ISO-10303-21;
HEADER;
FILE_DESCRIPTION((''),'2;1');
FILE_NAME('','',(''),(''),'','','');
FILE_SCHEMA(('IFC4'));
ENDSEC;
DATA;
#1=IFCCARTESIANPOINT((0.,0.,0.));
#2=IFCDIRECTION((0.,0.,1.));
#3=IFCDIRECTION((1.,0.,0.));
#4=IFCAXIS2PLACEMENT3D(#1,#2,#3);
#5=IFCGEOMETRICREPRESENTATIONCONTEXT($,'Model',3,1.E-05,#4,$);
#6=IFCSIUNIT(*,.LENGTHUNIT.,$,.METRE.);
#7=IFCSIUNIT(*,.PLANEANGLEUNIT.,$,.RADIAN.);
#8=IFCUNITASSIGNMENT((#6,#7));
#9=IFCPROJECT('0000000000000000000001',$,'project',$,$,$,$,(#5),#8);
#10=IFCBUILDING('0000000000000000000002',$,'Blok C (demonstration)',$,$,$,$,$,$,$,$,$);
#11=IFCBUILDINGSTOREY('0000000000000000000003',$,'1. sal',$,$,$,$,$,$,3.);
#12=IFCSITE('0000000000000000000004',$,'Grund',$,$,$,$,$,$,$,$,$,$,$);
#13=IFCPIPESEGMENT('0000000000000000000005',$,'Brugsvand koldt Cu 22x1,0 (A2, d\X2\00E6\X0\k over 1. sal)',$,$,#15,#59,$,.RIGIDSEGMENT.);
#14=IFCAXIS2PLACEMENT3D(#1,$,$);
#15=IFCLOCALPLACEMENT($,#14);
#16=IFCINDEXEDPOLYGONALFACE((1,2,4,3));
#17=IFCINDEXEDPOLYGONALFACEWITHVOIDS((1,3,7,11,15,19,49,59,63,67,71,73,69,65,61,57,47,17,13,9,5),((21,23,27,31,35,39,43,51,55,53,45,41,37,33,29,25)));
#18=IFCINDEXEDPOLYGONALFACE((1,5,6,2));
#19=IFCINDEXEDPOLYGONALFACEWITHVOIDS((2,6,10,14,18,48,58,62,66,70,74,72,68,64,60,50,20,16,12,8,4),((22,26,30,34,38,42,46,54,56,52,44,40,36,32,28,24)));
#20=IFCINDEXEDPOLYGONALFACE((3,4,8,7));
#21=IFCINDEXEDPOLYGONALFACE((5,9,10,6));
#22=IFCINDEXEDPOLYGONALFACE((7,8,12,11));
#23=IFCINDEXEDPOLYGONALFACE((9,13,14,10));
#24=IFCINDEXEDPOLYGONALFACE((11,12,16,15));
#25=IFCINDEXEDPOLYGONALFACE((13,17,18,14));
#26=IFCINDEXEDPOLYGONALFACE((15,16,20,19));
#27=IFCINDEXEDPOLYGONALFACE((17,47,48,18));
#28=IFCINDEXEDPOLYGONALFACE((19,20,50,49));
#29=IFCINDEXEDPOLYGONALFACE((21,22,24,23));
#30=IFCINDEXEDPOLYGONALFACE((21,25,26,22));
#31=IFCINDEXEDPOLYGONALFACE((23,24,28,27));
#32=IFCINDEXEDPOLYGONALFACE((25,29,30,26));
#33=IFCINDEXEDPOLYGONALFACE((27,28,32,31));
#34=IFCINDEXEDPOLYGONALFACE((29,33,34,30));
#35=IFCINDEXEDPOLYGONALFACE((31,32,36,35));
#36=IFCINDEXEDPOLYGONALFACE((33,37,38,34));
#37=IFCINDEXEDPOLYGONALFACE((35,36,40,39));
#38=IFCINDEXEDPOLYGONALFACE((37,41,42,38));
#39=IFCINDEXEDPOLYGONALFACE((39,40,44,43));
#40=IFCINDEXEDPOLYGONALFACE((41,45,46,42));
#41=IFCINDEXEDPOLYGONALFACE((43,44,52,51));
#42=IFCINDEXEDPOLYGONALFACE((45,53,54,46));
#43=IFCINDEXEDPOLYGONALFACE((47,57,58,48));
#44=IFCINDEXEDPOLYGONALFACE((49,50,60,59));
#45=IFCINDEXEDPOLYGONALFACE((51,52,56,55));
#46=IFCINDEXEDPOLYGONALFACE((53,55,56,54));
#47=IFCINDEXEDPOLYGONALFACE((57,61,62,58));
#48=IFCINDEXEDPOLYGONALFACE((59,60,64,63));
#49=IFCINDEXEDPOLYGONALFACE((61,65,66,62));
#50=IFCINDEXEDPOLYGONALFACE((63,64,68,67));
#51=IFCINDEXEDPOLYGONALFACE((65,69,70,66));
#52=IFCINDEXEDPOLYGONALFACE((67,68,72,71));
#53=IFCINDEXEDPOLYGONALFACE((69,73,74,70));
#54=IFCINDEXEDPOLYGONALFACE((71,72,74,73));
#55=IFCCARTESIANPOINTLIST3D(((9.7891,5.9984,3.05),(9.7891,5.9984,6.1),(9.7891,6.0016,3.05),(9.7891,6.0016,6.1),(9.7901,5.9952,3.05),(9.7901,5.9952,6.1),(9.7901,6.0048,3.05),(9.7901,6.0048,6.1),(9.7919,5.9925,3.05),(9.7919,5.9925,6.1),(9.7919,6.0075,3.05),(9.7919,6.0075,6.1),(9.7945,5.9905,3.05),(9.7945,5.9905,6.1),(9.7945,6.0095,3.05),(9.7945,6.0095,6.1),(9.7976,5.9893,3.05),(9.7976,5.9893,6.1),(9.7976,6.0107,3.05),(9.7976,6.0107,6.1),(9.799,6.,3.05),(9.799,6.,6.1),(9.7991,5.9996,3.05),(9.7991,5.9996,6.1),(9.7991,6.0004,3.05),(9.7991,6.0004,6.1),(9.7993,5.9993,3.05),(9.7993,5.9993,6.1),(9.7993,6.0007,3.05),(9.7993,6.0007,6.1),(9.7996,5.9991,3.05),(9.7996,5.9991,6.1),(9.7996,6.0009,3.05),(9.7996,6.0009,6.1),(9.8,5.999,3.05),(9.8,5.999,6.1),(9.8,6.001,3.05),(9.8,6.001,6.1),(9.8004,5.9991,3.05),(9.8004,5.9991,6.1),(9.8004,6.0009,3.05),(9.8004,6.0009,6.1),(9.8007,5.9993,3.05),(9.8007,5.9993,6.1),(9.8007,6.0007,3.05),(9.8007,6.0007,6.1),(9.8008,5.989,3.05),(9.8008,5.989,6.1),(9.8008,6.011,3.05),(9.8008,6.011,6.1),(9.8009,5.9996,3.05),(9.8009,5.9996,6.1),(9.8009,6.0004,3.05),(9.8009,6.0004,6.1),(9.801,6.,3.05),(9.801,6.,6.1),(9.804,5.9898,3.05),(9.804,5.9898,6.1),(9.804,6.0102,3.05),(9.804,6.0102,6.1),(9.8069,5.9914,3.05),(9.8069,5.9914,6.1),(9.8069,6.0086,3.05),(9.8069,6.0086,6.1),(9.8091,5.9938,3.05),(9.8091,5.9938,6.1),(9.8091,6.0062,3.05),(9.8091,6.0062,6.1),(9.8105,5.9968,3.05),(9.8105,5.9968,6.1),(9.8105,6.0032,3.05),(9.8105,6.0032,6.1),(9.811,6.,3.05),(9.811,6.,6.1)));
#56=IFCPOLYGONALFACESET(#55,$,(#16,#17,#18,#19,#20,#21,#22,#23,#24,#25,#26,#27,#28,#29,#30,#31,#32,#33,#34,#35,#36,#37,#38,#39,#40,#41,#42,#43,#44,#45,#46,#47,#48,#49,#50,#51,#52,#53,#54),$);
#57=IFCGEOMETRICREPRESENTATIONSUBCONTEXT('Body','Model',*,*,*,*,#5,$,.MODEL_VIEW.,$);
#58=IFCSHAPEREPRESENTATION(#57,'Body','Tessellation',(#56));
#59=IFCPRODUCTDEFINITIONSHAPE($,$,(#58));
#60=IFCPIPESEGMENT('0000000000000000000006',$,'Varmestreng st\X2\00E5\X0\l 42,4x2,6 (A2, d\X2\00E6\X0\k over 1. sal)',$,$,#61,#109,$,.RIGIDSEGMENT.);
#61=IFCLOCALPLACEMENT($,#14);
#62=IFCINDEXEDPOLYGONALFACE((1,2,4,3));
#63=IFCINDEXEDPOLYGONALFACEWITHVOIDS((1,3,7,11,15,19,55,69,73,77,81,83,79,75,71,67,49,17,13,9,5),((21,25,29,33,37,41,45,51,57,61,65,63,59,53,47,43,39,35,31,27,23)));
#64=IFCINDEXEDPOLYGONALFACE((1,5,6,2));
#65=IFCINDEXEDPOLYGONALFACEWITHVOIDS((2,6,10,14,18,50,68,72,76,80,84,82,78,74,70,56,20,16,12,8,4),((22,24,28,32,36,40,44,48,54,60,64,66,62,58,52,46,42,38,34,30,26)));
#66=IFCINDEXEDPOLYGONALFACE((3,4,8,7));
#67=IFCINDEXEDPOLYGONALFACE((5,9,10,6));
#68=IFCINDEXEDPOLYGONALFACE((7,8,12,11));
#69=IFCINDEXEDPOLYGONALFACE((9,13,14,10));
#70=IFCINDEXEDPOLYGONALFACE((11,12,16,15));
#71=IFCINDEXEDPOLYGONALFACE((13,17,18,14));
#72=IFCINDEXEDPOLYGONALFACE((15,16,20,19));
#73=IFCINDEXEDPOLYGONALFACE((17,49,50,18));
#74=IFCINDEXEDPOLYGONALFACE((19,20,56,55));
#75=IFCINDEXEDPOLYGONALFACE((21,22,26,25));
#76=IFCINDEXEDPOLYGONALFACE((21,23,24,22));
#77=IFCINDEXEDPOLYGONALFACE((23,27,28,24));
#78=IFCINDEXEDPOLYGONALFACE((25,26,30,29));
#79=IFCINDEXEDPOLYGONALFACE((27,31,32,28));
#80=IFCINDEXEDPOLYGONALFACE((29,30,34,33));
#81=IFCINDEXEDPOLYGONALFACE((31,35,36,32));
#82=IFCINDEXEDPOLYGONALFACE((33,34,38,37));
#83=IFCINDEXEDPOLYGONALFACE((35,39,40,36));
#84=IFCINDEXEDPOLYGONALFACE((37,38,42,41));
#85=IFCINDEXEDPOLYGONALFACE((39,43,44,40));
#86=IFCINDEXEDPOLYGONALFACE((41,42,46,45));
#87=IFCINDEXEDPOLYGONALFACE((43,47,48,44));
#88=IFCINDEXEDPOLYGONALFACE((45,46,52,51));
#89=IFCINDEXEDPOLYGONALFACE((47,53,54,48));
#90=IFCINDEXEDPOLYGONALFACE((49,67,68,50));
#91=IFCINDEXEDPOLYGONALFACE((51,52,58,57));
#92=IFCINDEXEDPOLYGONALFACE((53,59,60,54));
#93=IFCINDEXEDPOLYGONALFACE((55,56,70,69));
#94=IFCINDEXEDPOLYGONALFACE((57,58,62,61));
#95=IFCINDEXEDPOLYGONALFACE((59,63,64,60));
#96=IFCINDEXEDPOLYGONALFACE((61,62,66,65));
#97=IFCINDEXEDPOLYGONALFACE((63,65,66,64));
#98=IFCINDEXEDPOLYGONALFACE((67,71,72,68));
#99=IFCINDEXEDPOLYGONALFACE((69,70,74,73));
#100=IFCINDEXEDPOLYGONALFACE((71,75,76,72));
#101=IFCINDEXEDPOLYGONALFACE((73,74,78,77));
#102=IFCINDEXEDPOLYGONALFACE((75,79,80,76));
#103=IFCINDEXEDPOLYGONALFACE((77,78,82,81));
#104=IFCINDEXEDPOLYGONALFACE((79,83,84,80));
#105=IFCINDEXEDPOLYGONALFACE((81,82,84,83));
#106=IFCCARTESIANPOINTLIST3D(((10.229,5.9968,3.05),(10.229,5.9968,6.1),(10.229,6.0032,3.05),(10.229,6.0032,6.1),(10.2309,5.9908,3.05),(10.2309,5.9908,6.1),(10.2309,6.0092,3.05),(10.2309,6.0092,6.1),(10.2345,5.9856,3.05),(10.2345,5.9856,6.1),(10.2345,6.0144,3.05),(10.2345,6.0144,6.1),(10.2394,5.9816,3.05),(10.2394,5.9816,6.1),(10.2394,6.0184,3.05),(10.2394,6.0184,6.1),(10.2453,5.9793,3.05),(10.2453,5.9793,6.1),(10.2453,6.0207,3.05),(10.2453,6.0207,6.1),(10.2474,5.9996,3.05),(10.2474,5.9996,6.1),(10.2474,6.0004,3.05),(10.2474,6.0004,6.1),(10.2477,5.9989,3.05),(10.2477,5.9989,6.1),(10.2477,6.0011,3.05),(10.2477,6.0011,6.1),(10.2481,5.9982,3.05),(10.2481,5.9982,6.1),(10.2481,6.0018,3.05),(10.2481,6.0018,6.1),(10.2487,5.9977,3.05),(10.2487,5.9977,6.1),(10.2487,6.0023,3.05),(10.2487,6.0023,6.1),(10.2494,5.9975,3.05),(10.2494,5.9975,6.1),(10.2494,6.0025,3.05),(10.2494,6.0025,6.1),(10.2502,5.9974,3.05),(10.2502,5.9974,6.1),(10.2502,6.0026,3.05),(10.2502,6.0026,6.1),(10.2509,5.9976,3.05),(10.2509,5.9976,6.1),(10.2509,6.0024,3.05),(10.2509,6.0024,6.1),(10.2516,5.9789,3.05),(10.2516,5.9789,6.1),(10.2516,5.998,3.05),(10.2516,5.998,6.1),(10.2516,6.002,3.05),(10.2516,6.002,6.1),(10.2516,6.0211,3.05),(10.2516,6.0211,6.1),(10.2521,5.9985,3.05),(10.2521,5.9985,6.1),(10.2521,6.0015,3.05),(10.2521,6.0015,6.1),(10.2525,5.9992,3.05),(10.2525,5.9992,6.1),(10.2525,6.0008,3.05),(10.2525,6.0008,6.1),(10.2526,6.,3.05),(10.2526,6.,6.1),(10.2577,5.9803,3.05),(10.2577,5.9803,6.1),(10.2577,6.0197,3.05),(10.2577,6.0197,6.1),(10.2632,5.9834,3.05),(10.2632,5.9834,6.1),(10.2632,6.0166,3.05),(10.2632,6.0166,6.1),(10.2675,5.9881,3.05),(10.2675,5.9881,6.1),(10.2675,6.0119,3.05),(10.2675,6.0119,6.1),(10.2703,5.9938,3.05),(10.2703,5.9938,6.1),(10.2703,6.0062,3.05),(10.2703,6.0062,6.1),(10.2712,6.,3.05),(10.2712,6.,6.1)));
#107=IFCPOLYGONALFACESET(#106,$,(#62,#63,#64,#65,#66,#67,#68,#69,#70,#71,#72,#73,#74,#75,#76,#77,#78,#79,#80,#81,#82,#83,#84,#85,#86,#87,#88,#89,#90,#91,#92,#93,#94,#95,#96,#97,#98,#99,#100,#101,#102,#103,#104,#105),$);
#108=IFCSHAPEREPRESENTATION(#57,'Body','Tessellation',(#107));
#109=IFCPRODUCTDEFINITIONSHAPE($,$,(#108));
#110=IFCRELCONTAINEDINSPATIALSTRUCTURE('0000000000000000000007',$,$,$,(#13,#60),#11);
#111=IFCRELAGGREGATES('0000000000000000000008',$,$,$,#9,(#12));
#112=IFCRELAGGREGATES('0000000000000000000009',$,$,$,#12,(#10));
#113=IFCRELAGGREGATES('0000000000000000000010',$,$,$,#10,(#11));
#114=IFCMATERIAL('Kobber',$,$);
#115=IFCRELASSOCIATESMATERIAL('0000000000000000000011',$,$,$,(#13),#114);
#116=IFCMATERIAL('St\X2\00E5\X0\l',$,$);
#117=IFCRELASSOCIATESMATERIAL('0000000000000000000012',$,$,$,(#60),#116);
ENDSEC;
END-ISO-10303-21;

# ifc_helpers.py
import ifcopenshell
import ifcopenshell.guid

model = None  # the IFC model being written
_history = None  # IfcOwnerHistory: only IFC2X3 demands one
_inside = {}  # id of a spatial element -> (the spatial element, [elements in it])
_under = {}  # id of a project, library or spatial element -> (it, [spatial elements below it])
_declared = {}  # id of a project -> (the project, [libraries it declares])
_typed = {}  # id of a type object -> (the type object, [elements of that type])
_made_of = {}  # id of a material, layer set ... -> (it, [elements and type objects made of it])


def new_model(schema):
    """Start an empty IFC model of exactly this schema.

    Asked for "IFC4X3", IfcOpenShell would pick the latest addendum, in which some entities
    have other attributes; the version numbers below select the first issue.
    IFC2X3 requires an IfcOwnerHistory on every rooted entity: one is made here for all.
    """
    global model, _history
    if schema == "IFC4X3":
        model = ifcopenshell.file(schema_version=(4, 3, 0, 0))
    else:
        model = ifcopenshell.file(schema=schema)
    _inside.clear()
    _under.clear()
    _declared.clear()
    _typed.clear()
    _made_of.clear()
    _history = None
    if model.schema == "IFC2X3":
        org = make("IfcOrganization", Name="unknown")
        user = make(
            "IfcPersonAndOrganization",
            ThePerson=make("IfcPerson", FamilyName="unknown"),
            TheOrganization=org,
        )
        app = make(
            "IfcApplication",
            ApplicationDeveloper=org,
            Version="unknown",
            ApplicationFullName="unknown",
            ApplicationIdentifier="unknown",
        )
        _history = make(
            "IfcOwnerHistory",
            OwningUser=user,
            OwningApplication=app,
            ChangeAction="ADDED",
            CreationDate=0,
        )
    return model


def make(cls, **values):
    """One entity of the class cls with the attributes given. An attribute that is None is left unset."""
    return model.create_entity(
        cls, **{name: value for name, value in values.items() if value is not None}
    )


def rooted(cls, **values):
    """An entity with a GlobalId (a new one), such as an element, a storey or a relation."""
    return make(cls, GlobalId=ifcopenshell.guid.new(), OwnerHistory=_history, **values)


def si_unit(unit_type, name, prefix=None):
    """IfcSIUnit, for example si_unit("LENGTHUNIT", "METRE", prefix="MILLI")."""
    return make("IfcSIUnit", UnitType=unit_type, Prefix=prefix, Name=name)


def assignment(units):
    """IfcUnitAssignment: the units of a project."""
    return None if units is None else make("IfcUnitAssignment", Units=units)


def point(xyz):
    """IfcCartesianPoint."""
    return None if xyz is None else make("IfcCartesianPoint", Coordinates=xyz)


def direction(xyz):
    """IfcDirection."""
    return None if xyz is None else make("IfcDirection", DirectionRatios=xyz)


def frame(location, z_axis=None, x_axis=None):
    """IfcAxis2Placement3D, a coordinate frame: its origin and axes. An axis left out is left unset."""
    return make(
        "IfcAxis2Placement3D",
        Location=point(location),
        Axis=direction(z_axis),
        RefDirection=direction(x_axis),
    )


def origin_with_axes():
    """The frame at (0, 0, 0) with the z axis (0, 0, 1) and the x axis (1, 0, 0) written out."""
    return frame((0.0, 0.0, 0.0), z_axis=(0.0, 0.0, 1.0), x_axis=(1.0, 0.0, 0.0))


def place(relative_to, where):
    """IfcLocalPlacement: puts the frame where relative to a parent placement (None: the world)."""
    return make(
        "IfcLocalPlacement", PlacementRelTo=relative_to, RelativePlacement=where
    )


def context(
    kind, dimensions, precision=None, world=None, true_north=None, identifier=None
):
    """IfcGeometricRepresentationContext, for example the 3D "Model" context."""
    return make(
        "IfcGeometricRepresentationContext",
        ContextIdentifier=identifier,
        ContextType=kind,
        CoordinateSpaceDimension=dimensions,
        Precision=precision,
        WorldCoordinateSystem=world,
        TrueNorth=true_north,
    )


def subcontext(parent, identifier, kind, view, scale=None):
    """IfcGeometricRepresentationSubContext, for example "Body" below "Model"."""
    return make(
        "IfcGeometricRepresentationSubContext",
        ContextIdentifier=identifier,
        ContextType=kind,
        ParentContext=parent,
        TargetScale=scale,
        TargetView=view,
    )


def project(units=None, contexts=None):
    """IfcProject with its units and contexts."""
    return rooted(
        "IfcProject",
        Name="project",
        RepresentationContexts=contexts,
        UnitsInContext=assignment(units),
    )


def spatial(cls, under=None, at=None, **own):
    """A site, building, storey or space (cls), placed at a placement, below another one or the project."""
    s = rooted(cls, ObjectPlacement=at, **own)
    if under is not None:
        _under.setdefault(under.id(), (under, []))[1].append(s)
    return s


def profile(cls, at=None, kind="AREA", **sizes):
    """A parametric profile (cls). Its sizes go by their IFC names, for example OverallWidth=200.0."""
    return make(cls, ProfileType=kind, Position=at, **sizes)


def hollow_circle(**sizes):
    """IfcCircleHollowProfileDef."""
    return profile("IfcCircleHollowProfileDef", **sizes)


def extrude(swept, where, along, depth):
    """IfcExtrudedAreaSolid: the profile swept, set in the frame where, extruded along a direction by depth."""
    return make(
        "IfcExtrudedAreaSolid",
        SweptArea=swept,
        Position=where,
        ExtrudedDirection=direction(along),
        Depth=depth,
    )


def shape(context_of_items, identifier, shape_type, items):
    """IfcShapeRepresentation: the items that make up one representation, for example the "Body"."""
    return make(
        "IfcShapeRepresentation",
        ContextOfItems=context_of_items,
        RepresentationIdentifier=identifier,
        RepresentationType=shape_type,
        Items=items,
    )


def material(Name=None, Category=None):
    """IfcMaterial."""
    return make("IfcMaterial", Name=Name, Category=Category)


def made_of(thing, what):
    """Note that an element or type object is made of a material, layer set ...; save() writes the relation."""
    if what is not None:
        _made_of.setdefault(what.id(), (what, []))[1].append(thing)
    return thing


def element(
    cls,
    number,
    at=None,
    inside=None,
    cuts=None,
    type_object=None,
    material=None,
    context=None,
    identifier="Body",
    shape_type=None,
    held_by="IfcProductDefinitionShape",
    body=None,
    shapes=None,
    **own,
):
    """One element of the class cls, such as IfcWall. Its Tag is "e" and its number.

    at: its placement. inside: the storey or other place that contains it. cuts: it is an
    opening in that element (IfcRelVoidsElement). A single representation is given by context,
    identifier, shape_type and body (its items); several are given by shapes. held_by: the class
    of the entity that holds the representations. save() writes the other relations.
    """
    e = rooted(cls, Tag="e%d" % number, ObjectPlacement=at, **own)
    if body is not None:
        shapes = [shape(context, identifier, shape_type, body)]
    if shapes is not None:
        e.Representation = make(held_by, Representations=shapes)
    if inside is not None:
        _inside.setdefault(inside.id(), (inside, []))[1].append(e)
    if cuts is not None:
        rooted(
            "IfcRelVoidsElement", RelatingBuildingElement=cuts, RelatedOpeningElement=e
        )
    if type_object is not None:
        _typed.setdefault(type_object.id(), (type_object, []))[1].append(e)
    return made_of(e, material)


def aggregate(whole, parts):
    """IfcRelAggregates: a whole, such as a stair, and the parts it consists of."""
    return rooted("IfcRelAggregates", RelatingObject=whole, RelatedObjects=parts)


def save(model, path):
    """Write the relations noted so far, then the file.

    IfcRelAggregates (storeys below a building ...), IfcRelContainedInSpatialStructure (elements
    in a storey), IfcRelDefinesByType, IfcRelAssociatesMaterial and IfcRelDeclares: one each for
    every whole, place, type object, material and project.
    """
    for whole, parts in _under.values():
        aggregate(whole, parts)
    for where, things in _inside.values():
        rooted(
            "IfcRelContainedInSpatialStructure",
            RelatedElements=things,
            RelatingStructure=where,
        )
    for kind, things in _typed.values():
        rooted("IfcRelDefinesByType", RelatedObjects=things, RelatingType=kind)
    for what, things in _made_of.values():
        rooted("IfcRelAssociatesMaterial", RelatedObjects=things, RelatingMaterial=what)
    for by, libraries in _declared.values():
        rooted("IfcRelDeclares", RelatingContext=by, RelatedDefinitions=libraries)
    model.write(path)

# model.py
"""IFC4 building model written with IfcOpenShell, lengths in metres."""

from ifc_helpers import new_model, si_unit, frame, origin_with_axes, place, context, subcontext, project, spatial, hollow_circle, extrude, material, element, save


model = new_model("IFC4")

# Units and contexts
model_context = context("Model", 3, precision=1e-05, world=origin_with_axes())
body_context = subcontext(model_context, "Body", "Model", "MODEL_VIEW")
ifc_project = project(units=[si_unit("LENGTHUNIT", "METRE"), si_unit("PLANEANGLEUNIT", "RADIAN")], contexts=[model_context])

# Site, building, storey
site = spatial("IfcSite", under=ifc_project, Name="Grund")
building = spatial("IfcBuilding", under=site, Name="Blok C (demonstration)")
storey = spatial("IfcBuildingStorey", under=building, Name="1. sal", Elevation=3.0)

# Pipe segments
ifc_material_1 = material(Name="Kobber")
ifc_material_2 = material(Name="Stål")
pipe_segment_1_placement = place(None, origin_with_axes())
element("IfcPipeSegment", 1, at=pipe_segment_1_placement, inside=storey, material=ifc_material_1, Name="Brugsvand koldt Cu 22x1,0 (A2, dæk over 1. sal)", PredefinedType="RIGIDSEGMENT", context=body_context, shape_type="SweptSolid", body=[
    extrude(hollow_circle(Radius=0.011, WallThickness=0.01), frame((9.8, 6.0, 3.05), z_axis=(0.0, 0.0, 1.0), x_axis=(1.0, 0.0, 0.0)), (0.0, 0.0, 1.0), 3.05),
])
pipe_segment_2_placement = place(None, origin_with_axes())
element("IfcPipeSegment", 2, at=pipe_segment_2_placement, inside=storey, material=ifc_material_2, Name="Varmestreng stål 42,4x2,6 (A2, dæk over 1. sal)", PredefinedType="RIGIDSEGMENT", context=body_context, shape_type="SweptSolid", body=[
    extrude(hollow_circle(Radius=0.0212, WallThickness=0.0186), frame((10.25, 6.0, 3.05), z_axis=(0.0, 0.0, 1.0), x_axis=(1.0, 0.0, 0.0)), (0.0, 0.0, 1.0), 3.05),
])

save(model, "model.ifc")
